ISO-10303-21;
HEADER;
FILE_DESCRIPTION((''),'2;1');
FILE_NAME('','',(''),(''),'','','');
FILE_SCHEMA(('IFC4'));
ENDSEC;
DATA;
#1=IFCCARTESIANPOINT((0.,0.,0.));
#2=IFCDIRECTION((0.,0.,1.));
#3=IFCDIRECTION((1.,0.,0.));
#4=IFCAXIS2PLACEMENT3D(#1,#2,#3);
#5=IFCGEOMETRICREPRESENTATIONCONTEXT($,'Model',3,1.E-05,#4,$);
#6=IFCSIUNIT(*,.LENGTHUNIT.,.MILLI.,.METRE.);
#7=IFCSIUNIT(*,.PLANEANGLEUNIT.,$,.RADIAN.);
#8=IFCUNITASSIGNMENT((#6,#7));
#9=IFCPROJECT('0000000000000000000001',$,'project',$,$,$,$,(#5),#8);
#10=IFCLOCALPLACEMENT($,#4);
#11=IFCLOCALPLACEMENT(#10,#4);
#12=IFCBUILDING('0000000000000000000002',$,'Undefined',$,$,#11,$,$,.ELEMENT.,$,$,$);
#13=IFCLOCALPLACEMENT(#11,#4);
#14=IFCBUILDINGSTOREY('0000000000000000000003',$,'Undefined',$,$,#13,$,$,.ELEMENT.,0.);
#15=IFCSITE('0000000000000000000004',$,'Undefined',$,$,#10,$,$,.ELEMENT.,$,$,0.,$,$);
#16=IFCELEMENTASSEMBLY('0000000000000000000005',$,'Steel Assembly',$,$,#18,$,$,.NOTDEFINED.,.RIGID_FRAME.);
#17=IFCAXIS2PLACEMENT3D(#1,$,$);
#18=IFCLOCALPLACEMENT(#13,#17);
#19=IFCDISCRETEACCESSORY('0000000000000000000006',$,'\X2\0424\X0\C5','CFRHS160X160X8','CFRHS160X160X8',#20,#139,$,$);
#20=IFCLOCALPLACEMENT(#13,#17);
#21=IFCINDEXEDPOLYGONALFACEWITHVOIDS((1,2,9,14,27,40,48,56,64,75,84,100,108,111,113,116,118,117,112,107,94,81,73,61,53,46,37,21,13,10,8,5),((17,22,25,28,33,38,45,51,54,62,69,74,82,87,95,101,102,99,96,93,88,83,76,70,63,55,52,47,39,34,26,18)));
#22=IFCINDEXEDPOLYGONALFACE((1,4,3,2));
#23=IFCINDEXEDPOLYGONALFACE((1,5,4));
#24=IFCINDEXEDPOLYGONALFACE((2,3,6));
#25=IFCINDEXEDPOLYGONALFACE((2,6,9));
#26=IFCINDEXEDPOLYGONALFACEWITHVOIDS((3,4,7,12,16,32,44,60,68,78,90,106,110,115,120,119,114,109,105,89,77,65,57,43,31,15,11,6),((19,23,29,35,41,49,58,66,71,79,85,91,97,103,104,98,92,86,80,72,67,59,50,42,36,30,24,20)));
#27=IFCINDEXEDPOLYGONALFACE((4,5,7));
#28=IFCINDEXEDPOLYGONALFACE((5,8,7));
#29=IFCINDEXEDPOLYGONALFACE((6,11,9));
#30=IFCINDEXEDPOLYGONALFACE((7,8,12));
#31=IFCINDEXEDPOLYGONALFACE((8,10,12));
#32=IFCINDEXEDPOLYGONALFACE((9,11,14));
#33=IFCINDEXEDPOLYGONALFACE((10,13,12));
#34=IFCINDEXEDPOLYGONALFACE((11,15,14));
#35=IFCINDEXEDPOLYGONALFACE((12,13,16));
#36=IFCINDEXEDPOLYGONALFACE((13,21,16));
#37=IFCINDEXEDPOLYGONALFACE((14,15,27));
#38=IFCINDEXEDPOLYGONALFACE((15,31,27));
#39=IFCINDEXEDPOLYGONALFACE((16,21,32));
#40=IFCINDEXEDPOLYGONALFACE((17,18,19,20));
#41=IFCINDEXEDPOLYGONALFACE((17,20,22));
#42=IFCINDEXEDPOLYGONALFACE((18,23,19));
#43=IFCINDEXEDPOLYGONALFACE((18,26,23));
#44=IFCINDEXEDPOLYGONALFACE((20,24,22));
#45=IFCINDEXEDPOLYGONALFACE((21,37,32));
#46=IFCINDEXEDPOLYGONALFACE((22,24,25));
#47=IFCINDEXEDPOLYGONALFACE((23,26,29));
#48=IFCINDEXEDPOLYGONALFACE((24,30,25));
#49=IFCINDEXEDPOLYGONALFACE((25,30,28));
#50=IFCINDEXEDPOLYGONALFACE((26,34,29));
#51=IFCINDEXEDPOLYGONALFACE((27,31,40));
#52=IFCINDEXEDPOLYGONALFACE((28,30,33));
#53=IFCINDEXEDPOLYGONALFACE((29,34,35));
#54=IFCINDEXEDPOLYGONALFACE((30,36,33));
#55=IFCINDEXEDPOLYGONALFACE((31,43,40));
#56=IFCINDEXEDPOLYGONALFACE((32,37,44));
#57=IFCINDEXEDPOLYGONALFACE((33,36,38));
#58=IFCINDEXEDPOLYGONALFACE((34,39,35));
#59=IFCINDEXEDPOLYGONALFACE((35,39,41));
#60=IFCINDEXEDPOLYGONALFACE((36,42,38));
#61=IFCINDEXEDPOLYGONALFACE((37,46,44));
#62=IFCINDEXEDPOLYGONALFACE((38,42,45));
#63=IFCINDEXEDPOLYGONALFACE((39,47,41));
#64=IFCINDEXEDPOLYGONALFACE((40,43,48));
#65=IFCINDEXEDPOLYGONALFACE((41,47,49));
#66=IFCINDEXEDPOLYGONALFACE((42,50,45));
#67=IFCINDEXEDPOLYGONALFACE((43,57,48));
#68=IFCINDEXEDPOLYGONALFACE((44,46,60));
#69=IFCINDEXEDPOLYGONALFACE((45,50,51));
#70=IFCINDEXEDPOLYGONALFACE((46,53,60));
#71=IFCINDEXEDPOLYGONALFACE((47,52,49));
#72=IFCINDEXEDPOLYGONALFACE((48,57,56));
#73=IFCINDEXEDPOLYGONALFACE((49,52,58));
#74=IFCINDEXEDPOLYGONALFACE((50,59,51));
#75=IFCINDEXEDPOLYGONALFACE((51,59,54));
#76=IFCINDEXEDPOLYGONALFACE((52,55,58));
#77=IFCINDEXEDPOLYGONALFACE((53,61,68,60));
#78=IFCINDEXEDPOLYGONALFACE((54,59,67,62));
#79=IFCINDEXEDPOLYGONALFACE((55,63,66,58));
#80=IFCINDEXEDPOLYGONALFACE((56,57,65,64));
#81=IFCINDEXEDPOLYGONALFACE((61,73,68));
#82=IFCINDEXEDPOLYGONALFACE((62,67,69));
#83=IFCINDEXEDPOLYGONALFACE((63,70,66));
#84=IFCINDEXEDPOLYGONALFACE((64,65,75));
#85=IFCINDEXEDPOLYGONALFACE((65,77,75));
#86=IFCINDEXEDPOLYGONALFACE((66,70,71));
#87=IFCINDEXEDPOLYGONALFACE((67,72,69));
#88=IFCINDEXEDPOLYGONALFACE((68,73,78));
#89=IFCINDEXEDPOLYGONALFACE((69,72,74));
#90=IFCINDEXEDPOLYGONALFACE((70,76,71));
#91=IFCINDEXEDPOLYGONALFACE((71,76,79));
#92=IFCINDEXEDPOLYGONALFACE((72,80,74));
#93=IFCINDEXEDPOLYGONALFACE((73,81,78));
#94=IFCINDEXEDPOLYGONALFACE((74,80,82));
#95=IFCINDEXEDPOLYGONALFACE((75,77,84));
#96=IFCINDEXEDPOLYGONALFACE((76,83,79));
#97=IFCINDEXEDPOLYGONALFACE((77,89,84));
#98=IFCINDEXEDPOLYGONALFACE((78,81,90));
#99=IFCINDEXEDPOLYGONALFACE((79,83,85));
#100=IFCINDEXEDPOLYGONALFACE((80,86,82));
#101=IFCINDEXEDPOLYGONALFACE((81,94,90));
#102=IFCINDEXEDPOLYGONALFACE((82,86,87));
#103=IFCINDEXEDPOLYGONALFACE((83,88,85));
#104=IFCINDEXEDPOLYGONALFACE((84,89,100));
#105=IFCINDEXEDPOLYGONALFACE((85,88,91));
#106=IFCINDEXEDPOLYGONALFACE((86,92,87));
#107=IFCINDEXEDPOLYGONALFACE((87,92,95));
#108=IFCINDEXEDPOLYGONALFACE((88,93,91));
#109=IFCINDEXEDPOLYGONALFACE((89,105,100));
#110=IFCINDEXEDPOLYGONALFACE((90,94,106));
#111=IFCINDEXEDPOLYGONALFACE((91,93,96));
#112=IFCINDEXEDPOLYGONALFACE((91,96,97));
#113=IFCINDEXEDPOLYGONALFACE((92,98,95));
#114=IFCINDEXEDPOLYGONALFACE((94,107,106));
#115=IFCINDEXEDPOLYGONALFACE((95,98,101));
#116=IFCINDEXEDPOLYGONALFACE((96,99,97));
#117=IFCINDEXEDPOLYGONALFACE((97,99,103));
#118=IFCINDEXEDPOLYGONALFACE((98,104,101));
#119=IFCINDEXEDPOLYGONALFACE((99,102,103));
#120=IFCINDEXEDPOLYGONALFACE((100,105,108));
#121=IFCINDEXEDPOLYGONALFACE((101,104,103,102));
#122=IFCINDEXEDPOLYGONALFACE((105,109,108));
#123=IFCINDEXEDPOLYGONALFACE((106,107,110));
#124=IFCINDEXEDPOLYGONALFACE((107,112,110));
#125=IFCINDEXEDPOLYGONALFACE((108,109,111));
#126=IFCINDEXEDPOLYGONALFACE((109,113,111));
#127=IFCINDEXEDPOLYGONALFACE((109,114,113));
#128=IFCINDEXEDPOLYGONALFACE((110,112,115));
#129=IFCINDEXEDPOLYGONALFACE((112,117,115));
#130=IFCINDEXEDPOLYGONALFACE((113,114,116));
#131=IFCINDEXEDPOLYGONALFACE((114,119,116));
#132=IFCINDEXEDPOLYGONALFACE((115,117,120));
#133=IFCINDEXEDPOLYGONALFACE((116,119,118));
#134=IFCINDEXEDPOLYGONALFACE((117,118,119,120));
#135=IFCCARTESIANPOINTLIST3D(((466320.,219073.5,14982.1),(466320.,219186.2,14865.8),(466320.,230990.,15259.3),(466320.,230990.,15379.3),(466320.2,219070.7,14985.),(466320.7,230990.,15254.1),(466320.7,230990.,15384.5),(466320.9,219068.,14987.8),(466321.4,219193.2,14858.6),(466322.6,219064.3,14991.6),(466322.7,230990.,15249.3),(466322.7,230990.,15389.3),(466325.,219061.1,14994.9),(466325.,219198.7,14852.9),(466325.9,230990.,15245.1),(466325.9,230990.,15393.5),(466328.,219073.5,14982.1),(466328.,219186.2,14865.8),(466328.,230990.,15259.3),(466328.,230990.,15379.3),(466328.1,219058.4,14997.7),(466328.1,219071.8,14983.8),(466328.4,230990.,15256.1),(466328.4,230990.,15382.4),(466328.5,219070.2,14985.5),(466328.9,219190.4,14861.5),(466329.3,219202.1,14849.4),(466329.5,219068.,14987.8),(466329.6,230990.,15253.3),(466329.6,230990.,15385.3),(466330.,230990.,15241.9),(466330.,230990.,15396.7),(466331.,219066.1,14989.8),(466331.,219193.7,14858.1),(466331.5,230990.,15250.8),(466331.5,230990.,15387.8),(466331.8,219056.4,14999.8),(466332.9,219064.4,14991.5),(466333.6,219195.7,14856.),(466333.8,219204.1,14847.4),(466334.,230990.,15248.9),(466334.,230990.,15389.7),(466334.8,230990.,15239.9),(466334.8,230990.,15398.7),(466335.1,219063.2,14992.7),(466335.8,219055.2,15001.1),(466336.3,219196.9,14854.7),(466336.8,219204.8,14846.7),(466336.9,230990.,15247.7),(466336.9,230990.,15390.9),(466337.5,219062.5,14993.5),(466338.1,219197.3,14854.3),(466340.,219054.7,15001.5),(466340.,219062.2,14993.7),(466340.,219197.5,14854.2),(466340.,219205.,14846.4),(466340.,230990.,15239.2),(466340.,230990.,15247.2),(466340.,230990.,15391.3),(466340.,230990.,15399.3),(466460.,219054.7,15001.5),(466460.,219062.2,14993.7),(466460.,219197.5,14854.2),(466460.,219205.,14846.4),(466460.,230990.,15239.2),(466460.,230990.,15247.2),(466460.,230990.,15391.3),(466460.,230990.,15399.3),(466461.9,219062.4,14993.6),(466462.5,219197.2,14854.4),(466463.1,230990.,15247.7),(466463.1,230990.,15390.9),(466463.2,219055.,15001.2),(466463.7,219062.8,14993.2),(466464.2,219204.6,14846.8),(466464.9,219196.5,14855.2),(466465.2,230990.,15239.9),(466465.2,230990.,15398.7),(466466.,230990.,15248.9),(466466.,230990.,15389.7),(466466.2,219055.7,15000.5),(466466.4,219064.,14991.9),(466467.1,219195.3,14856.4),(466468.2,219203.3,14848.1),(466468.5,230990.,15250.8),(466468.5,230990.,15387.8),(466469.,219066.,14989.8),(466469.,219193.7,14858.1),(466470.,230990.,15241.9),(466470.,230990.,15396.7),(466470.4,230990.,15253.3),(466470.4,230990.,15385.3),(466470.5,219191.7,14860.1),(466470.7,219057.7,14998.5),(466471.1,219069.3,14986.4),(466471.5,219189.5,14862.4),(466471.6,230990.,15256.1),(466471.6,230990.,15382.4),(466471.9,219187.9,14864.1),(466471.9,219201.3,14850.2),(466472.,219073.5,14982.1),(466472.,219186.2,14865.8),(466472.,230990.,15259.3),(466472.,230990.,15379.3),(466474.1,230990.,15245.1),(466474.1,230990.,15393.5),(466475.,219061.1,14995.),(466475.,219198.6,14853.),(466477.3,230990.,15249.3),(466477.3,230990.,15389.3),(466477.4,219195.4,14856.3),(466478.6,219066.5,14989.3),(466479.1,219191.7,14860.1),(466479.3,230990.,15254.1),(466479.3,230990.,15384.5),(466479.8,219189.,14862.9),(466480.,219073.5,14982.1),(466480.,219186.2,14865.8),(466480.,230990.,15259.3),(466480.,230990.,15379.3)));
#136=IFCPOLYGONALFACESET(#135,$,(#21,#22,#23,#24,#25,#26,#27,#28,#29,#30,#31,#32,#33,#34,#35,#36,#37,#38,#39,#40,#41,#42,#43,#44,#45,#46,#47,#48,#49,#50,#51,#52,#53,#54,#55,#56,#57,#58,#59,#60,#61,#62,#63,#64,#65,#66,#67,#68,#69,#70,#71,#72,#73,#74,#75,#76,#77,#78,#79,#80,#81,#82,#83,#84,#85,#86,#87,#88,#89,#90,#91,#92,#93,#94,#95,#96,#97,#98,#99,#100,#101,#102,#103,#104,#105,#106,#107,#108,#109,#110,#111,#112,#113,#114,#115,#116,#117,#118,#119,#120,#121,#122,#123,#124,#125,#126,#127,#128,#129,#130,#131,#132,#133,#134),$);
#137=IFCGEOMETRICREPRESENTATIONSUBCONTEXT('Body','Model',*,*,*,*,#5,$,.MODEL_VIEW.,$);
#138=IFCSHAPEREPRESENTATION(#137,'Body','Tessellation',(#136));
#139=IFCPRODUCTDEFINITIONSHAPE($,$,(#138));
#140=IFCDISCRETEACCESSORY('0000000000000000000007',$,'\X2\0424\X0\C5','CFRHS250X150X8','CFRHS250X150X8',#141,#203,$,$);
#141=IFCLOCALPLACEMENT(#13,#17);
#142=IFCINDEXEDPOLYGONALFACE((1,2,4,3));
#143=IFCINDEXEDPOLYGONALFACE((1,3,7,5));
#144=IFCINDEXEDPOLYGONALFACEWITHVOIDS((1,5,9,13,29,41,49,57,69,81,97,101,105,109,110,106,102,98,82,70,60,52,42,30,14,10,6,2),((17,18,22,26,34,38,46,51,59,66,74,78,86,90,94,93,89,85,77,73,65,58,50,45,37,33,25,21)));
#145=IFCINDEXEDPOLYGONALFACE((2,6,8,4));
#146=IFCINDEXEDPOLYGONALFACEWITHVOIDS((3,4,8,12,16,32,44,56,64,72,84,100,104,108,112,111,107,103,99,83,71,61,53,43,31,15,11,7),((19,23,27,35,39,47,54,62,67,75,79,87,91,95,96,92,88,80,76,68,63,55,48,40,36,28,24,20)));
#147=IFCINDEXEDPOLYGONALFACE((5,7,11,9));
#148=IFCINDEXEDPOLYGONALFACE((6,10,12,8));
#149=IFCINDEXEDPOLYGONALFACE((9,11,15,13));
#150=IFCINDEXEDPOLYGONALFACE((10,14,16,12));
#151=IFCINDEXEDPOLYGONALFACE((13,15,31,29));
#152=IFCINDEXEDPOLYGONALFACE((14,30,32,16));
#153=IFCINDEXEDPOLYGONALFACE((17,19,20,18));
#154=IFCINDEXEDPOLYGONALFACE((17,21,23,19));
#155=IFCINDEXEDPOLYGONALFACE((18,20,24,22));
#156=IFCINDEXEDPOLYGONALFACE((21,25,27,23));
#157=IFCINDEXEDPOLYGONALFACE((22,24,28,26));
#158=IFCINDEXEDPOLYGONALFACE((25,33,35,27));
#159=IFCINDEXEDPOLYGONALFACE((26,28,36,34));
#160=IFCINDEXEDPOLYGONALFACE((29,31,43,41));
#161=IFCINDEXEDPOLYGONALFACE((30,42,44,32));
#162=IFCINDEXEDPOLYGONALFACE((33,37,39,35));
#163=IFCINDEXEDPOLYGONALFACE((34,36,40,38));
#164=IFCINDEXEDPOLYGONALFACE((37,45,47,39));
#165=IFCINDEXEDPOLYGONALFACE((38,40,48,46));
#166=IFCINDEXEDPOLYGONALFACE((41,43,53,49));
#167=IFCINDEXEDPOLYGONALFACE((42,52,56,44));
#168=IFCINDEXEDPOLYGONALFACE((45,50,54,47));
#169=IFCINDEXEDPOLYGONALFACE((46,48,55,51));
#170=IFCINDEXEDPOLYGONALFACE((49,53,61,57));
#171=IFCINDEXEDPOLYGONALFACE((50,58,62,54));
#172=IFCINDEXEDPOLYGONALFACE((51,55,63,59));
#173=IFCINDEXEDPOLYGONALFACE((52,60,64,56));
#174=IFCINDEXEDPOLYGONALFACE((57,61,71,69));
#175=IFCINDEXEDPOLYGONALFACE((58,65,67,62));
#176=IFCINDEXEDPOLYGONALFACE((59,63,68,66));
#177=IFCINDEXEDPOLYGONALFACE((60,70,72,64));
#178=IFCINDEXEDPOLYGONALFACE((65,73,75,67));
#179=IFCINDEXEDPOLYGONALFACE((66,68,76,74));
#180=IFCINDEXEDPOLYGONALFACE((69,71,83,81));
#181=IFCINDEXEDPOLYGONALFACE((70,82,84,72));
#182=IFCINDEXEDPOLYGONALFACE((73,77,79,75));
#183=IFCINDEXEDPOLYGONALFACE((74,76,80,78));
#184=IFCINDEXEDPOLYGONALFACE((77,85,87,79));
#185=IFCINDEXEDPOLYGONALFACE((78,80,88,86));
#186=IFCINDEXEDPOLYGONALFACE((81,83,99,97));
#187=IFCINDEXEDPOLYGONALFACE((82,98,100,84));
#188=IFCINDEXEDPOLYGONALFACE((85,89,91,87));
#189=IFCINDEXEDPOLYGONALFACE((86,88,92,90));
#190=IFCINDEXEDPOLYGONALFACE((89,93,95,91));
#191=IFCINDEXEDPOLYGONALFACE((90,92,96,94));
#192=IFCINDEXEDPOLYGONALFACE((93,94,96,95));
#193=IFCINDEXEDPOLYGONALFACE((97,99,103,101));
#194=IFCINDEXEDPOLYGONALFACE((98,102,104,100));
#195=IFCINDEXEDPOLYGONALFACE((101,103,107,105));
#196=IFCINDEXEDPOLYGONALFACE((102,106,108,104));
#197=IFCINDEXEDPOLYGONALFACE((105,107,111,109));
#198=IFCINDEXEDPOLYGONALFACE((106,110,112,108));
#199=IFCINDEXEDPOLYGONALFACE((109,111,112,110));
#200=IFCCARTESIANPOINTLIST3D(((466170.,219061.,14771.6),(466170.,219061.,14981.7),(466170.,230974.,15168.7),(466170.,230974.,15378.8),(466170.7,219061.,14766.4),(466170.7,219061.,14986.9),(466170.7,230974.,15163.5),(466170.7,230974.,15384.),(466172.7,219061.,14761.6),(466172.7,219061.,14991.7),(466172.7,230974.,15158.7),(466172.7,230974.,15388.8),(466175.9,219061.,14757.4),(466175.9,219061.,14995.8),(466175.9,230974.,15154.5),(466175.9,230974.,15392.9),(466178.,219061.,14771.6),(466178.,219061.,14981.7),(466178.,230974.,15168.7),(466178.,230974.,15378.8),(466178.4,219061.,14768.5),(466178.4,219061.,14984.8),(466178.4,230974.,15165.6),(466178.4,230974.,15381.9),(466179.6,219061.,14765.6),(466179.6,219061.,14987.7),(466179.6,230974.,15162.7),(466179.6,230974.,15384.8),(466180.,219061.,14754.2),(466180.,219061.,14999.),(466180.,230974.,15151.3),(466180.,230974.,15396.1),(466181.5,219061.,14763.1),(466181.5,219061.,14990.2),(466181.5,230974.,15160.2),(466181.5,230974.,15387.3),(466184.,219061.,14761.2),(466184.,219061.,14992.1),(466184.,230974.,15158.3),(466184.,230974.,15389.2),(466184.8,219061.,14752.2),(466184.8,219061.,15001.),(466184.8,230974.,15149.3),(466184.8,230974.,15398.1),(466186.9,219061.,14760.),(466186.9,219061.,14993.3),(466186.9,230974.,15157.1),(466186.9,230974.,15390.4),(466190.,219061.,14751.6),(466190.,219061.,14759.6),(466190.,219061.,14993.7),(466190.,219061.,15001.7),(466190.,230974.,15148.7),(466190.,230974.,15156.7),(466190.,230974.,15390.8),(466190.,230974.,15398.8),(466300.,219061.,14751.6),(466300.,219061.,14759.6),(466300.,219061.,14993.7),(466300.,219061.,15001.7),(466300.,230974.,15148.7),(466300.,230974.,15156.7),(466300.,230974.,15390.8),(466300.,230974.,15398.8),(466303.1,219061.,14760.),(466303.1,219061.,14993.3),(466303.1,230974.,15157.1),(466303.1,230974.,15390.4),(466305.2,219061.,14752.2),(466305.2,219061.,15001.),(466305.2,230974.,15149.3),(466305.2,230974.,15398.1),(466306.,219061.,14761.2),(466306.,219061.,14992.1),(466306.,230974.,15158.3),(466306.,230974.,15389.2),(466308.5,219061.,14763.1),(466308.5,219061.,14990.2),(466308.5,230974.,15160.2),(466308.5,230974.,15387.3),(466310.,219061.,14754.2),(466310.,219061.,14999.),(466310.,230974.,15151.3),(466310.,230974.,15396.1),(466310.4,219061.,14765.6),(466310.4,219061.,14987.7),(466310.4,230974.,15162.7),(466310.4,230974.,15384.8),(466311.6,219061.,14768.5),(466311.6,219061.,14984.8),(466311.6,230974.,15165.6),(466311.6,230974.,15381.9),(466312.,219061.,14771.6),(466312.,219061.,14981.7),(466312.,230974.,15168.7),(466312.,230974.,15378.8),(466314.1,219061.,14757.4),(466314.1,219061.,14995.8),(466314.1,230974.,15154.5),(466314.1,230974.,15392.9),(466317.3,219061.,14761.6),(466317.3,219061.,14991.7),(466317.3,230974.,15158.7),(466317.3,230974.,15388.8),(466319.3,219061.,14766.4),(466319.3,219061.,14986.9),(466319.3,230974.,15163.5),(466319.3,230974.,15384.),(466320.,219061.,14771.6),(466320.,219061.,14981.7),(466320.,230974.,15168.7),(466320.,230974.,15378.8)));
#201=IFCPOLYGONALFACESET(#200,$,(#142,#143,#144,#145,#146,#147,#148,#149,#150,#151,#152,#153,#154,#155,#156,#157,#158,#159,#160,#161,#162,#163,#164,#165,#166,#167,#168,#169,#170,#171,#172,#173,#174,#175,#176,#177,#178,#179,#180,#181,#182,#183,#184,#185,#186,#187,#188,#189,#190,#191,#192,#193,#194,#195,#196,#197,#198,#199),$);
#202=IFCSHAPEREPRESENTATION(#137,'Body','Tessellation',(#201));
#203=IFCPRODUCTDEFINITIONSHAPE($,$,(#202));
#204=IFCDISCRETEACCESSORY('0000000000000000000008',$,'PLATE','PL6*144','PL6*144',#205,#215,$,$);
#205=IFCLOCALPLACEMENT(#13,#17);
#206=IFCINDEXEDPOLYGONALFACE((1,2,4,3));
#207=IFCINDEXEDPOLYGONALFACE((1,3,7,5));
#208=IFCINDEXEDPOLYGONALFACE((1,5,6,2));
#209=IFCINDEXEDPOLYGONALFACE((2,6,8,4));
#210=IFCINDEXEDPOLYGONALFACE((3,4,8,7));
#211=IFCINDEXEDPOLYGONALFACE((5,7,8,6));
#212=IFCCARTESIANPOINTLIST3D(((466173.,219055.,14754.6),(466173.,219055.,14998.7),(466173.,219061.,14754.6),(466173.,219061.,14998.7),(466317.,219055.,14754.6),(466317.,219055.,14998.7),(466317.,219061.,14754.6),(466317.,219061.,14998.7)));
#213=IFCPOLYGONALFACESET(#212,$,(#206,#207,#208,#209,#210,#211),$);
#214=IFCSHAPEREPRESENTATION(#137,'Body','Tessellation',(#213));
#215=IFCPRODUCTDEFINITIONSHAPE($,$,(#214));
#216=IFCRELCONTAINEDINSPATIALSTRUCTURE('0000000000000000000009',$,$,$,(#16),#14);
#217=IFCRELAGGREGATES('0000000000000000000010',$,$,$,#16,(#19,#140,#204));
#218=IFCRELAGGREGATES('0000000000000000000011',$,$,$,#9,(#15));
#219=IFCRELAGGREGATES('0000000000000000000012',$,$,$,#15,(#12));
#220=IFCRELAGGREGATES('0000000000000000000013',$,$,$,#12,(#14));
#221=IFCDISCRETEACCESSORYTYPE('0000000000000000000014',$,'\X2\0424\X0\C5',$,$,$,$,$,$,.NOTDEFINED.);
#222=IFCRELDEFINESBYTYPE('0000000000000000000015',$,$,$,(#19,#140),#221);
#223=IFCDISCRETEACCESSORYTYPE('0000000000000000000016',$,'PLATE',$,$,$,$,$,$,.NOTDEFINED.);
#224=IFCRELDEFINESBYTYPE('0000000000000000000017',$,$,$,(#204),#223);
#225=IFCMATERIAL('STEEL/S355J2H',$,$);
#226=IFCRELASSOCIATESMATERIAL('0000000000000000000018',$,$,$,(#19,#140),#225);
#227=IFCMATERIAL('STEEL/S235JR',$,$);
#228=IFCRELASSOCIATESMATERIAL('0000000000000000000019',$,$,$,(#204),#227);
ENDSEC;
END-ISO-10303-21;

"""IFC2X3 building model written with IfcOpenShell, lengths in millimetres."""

from ifc_helpers import new_model, si_unit, frame, origin_with_axes, origin_2d_with_axis, place, context, subcontext, project, spatial, rectangle, hollow_rectangle, extrude, clip, halfspace, material, type_object, element, aggregate, save


model = new_model("IFC2X3")

# Units and contexts
model_context = context("Model", 3, precision=1e-05, world=origin_with_axes())
body_context = subcontext(model_context, "Body", "Model", "MODEL_VIEW")
ifc_project = project(units=[si_unit("LENGTHUNIT", "METRE", prefix="MILLI"), si_unit("PLANEANGLEUNIT", "RADIAN")], contexts=[model_context])

# Site, building, storey
site_placement = place(None, origin_with_axes())
site = spatial("IfcSite", under=ifc_project, at=site_placement, Name="Undefined", CompositionType="ELEMENT", RefElevation=0.0)
building_placement = place(site_placement, origin_with_axes())
building = spatial("IfcBuilding", under=site, at=building_placement, Name="Undefined", CompositionType="ELEMENT")
storey_placement = place(building_placement, origin_with_axes())
storey = spatial("IfcBuildingStorey", under=building, at=storey_placement, Name="Undefined", CompositionType="ELEMENT", Elevation=0.0)

# Shared definitions
ifc_material_1 = material(Name="STEEL/S355J2H")

# Element assembly, discrete accessories
assembly_1_placement = place(storey_placement, origin_with_axes())
assembly_1 = element("IfcElementAssembly", 1, at=assembly_1_placement, inside=storey, Name="Steel Assembly", AssemblyPlace="NOTDEFINED", PredefinedType="RIGID_FRAME")
discrete_accessory_type_1 = type_object("IfcDiscreteAccessoryType", Name="ФC5")
discrete_accessory_1_placement = place(assembly_1_placement, frame((466400.0, 219040.3, 14921.0), z_axis=(0.0, -0.033315, 0.999445), x_axis=(0.0, 0.999445, 0.033315)))
discrete_accessory_1 = element("IfcDiscreteAccessory", 2, at=discrete_accessory_1_placement, type_object=discrete_accessory_type_1, material=ifc_material_1, Name="ФC5", Description="CFRHS160X160X8", ObjectType="CFRHS160X160X8", context=body_context, shape_type="Clipping", body=[
    clip(clip(clip(clip(extrude(hollow_rectangle(XDim=160.0, YDim=160.0, WallThickness=8.0, InnerFilletRadius=12.0, OuterFilletRadius=20.0, at=origin_2d_with_axis()), frame((11979.0, 0.0, 0.0), z_axis=(-1.0, 0.0, 0.0), x_axis=(0.0, -1.0, 0.0)), (0.0, 0.0, 1.0), 11979.0), halfspace(frame((11973.0, -90.0, -100.0), z_axis=(0.999445, 0.0, -0.033315), x_axis=(0.033315, 0.0, 0.999445)), False)), halfspace(frame((7.4, 75.0, -70.0), z_axis=(-0.999445, 0.0, 0.033315), x_axis=(0.033315, 0.0, 0.999445)), False)), halfspace(frame((11954.0, 75.0, -70.0), z_axis=(0.999445, 0.0, -0.033315), x_axis=(0.0, -1.0, 0.0)), False)), halfspace(frame((162.1, -80.0, -80.0), z_axis=(-0.740939, 0.0, -0.671572), x_axis=(0.0, 1.0, 0.0)), False)),
])
discrete_accessory_2_placement = place(assembly_1_placement, frame((466245.0, 219041.8, 14876.0), z_axis=(0.0, -0.033315, 0.999445), x_axis=(0.0, 0.999445, 0.033315)))
discrete_accessory_2 = element("IfcDiscreteAccessory", 3, at=discrete_accessory_2_placement, type_object=discrete_accessory_type_1, material=ifc_material_1, Name="ФC5", Description="CFRHS250X150X8", ObjectType="CFRHS250X150X8", context=body_context, shape_type="Clipping", body=[
    clip(clip(clip(clip(clip(extrude(hollow_rectangle(XDim=150.0, YDim=250.0, WallThickness=8.0, InnerFilletRadius=12.0, OuterFilletRadius=20.0, at=origin_2d_with_axis()), frame((11943.1, 0.0, 0.0), z_axis=(-1.0, 0.0, 0.0), x_axis=(0.0, -1.0, 0.0)), (0.0, 0.0, 1.0), 11928.0), halfspace(frame((11973.0, -165.0, -55.0), z_axis=(0.999445, 0.0, -0.033315), x_axis=(0.033315, 0.0, 0.999445)), False)), halfspace(frame((7.4, 0.0, -25.0), z_axis=(-0.999445, 0.0, 0.033315), x_axis=(0.033315, 0.0, 0.999445)), False)), halfspace(frame((11954.0, 0.0, -25.0), z_axis=(0.999445, 0.0, -0.033315), x_axis=(0.0, -1.0, 0.0)), False)), halfspace(frame((11934.7, 0.0, -125.0), z_axis=(-0.999445, 0.0, 0.033315), x_axis=(0.0, 1.0, 0.0)), True)), halfspace(frame((15.1, 0.0, -125.0), z_axis=(0.999445, 0.0, -0.033315), x_axis=(0.0, -1.0, 0.0)), True)),
])
ifc_material_2 = material(Name="STEEL/S235JR")
discrete_accessory_type_2 = type_object("IfcDiscreteAccessoryType", Name="PLATE")
discrete_accessory_3_placement = place(assembly_1_placement, frame((466245.0, 219058.0, 14754.6), z_axis=(0.0, 0.0, 1.0), x_axis=(1.0, 0.0, 0.0)))
discrete_accessory_3 = element("IfcDiscreteAccessory", 4, at=discrete_accessory_3_placement, type_object=discrete_accessory_type_2, material=ifc_material_2, Name="PLATE", Description="PL6*144", ObjectType="PL6*144", context=body_context, shape_type="SweptSolid", body=[
    extrude(rectangle(XDim=6.0, YDim=144.0, at=origin_2d_with_axis()), frame((0.0, 0.0, 244.1), z_axis=(0.0, 0.0, -1.0), x_axis=(0.0, 1.0, 0.0)), (0.0, 0.0, 1.0), 244.1),
])
aggregate(assembly_1, [discrete_accessory_1, discrete_accessory_2, discrete_accessory_3])

save(model, "model.ifc")
